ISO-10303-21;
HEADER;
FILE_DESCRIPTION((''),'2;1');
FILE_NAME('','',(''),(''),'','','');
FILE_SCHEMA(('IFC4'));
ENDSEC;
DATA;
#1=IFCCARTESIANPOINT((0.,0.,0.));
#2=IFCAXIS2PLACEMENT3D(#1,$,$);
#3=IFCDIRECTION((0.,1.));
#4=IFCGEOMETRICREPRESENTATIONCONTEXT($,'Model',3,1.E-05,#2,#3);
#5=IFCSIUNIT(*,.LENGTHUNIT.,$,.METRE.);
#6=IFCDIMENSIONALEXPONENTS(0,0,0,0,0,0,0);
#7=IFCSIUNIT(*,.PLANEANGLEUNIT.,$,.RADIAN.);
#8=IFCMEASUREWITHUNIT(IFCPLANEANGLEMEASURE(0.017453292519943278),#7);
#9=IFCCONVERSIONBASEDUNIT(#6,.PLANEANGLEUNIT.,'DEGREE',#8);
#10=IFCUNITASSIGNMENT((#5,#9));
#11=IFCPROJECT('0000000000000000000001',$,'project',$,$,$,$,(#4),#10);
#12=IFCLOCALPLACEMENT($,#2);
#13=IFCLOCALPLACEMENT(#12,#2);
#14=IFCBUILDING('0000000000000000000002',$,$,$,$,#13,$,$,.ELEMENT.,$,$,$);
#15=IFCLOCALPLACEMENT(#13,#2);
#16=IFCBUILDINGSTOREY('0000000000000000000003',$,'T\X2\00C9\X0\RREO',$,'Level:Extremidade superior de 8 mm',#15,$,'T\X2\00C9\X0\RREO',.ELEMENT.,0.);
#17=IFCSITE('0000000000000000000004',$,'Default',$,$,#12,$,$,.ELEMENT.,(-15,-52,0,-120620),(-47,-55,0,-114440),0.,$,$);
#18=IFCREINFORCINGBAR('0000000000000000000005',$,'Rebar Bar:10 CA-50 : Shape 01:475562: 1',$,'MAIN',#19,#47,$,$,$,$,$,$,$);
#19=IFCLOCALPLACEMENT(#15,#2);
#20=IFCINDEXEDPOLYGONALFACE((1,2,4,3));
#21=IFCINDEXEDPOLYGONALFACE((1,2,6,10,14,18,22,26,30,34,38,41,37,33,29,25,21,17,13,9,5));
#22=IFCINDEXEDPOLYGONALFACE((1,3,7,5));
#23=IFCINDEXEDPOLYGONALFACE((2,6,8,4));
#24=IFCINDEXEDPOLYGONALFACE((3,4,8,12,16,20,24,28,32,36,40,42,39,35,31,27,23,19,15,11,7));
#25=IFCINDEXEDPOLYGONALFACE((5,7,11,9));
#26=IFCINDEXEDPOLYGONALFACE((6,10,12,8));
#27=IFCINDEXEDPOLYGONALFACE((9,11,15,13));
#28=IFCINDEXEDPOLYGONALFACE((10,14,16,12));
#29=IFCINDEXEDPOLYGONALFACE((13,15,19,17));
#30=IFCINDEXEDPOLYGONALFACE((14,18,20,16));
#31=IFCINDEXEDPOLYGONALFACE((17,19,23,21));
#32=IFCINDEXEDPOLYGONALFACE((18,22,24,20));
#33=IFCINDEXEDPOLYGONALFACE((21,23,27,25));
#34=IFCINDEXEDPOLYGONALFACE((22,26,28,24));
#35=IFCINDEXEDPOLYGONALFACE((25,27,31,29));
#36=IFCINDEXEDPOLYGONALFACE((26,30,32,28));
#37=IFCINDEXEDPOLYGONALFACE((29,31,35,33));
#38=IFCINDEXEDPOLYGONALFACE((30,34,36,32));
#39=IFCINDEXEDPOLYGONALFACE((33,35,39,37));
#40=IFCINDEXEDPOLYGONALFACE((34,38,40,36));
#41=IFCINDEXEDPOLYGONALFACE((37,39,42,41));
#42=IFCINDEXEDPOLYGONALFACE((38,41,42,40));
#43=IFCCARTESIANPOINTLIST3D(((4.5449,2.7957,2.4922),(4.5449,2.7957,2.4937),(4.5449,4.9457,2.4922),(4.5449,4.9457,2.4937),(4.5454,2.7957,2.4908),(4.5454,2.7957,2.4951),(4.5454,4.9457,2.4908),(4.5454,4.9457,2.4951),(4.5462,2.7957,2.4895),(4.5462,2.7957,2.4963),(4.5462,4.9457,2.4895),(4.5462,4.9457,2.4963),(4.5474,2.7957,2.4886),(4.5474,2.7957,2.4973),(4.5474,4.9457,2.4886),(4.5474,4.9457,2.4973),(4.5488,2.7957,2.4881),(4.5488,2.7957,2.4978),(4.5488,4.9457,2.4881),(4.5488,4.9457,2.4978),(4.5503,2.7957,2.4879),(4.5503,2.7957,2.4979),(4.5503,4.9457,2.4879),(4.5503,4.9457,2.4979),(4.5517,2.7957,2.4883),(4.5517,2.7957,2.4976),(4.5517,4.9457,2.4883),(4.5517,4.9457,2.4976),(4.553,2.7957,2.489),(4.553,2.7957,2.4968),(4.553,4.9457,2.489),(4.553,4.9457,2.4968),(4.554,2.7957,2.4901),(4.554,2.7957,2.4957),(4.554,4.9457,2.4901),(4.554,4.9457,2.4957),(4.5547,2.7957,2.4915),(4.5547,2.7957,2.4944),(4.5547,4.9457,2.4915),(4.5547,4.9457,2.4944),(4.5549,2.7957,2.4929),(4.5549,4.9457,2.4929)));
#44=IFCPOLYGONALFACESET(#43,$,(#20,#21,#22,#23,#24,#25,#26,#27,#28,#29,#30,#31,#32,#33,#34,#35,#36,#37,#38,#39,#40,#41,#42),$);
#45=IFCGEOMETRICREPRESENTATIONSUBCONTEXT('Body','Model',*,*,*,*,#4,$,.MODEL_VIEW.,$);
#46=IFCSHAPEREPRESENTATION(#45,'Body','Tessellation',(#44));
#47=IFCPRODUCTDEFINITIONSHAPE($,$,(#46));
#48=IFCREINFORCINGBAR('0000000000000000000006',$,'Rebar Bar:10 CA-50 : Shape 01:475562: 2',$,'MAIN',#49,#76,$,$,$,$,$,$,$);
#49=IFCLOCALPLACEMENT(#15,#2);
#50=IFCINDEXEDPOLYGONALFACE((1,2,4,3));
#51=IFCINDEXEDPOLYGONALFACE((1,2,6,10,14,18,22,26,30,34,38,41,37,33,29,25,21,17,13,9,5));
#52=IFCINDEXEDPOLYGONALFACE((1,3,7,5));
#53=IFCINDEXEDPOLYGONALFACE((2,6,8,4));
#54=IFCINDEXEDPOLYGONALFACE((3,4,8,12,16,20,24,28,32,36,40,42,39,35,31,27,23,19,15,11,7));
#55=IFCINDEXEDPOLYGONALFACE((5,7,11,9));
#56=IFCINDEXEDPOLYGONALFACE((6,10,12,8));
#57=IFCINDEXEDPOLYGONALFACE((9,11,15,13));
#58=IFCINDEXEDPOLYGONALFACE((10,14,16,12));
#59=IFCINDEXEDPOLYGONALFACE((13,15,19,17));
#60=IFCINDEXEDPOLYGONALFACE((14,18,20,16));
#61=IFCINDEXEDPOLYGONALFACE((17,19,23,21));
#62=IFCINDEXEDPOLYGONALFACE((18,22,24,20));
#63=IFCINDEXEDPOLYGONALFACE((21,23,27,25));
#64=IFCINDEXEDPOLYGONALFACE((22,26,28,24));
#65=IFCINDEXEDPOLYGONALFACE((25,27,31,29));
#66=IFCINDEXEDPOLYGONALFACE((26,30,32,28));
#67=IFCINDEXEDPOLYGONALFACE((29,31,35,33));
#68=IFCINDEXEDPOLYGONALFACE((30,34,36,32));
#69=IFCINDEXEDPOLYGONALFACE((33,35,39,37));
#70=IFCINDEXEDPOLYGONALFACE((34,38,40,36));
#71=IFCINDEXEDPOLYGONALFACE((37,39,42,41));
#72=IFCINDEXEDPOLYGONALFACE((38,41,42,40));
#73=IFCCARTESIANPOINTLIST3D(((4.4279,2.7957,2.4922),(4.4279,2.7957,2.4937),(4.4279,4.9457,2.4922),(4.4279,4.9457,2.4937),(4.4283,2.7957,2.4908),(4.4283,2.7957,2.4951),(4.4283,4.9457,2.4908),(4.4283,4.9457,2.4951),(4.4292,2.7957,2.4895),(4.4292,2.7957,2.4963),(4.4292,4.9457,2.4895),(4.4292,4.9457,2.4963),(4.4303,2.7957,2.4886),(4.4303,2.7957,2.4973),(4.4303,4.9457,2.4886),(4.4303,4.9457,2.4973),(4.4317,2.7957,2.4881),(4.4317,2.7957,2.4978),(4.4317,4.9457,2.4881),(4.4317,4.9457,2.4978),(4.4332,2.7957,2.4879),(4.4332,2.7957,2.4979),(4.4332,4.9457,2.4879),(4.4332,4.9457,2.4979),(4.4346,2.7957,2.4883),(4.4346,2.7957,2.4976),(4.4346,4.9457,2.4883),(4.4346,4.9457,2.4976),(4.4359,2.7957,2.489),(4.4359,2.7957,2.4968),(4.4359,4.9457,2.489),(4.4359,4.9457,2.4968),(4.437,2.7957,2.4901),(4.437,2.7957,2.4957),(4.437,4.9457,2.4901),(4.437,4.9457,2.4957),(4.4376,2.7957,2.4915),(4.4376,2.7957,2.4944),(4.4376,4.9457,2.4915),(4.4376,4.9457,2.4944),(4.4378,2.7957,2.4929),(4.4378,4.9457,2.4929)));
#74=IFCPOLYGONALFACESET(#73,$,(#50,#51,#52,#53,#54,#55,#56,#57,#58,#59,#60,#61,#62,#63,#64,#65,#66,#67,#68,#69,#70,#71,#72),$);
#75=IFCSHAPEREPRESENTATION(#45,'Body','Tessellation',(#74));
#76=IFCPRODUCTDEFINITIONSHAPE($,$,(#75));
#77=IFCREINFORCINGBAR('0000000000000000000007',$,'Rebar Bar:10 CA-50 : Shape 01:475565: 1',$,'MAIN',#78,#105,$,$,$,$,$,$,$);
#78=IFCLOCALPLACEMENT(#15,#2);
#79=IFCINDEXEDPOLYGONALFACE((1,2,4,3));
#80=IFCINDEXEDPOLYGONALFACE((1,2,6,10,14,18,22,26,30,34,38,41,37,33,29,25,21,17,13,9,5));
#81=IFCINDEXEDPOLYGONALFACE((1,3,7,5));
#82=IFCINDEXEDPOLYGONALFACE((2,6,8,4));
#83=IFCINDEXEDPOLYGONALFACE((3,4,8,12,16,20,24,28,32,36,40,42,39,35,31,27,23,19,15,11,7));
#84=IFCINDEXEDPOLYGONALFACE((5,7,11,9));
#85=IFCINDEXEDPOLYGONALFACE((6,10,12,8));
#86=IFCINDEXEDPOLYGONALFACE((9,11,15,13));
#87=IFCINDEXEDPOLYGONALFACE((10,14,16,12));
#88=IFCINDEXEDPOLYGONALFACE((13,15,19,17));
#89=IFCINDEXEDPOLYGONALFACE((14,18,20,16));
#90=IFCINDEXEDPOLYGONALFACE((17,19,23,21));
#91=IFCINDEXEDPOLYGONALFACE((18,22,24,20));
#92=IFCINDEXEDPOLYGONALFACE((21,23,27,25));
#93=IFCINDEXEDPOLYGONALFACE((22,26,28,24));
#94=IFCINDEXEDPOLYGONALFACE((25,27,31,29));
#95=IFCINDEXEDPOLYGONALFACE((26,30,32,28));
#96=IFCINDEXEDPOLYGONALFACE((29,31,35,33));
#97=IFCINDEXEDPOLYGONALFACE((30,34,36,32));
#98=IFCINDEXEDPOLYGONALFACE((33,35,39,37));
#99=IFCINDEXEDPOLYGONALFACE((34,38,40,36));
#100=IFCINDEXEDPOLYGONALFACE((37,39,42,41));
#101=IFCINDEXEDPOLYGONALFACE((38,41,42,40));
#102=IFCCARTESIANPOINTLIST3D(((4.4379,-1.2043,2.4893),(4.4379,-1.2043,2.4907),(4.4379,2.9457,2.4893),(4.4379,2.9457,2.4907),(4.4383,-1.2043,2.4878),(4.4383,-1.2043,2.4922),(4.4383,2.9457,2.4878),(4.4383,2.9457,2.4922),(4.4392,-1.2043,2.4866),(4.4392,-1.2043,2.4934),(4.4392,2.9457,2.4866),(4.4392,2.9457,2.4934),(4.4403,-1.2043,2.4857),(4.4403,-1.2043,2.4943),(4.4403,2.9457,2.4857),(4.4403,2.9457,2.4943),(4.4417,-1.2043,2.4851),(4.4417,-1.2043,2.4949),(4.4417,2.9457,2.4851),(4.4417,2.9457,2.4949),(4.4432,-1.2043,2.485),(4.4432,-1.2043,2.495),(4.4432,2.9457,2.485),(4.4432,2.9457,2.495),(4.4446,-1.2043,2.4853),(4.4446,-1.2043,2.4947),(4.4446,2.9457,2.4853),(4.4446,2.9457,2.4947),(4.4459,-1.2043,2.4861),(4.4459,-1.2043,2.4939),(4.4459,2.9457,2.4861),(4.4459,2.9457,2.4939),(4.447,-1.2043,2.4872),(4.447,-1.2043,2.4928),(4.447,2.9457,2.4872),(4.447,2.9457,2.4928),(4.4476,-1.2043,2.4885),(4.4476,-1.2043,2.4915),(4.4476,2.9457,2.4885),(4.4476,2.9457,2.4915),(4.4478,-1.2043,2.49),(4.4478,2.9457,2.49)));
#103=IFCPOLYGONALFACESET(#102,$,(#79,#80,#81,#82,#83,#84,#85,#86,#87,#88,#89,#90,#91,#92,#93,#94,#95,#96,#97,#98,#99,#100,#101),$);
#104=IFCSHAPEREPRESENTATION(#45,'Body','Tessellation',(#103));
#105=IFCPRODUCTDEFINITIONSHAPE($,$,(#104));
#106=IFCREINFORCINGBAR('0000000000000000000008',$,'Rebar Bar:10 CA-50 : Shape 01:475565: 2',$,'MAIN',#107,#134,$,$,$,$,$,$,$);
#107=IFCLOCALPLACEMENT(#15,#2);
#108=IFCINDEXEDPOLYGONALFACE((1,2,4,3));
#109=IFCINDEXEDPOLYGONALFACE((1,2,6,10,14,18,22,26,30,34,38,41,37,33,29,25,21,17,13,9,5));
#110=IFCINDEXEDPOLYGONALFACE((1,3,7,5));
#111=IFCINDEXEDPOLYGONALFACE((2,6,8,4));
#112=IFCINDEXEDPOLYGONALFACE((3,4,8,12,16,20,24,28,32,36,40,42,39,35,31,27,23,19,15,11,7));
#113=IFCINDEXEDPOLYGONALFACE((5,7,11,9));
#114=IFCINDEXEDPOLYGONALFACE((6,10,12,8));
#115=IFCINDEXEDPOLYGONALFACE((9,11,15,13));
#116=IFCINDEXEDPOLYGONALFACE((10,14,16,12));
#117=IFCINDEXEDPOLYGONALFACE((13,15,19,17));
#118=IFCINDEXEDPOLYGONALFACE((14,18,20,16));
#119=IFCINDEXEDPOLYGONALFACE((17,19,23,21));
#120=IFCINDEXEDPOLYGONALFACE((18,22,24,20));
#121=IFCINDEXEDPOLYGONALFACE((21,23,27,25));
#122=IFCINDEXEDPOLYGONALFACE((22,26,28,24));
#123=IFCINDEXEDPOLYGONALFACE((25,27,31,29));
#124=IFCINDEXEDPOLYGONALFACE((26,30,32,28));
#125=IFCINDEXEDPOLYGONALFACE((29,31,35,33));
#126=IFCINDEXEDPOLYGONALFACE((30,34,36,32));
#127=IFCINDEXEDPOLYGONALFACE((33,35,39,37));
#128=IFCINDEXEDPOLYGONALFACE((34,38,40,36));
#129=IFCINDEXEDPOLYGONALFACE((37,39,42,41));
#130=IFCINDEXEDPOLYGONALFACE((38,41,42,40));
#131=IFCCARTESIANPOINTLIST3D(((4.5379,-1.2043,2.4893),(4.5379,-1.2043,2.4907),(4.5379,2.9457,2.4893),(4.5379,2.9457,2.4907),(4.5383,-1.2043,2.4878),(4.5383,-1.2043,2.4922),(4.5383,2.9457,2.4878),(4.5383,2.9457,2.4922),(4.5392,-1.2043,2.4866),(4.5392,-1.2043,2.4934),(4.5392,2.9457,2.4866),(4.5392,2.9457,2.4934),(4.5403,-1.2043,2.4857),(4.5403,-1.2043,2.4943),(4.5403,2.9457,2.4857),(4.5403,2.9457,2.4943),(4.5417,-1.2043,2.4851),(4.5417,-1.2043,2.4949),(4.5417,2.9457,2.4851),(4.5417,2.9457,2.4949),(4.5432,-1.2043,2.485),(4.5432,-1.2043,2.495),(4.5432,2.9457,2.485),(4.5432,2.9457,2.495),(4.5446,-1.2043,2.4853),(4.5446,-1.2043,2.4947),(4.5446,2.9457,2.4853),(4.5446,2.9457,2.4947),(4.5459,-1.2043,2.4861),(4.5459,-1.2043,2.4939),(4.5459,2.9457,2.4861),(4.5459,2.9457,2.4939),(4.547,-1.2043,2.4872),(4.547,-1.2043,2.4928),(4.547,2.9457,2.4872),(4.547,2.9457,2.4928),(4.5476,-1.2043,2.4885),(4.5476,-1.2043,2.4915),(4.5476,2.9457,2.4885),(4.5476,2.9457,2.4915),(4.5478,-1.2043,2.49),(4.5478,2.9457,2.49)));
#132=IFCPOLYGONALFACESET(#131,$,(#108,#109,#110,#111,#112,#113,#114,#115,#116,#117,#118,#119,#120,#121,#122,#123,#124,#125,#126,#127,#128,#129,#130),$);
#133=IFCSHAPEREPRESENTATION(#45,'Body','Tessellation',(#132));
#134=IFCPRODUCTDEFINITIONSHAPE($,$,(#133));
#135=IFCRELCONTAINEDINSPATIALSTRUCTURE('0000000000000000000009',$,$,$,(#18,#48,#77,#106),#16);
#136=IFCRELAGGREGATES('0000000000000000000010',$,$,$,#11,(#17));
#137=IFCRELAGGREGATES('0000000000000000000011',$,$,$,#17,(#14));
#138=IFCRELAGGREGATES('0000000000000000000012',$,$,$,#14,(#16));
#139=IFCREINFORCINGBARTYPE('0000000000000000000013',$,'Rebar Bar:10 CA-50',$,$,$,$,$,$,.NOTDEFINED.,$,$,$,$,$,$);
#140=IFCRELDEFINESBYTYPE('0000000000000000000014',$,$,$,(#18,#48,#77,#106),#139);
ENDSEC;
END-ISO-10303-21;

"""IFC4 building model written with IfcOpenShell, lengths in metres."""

from ifc_helpers import new_model, entity, si_unit, converted_unit, direction, origin, place, context, subcontext, project, spatial, type_object, element, save


model = new_model("IFC4")

# Units and contexts
model_context = context("Model", 3, precision=1e-05, world=origin(), true_north=direction((0.0, 1.0)))
body_context = subcontext(model_context, "Body", "Model", "MODEL_VIEW")
ifc_project = project(units=[si_unit("LENGTHUNIT", "METRE"), converted_unit("PLANEANGLEUNIT", "DEGREE", entity("IfcPlaneAngleMeasure", 0.017453292519943278), si_unit("PLANEANGLEUNIT", "RADIAN"), dimensions=[0, 0, 0, 0, 0, 0, 0])], contexts=[model_context])

# Site, building, storey
site_placement = place(None, origin())
site = spatial("IfcSite", under=ifc_project, at=site_placement, Name="Default", CompositionType="ELEMENT", RefLatitude=(-15, -52, 0, -120620), RefLongitude=(-47, -55, 0, -114440), RefElevation=0.0)
building_placement = place(site_placement, origin())
building = spatial("IfcBuilding", under=site, at=building_placement, CompositionType="ELEMENT")
storey_placement = place(building_placement, origin())
storey = spatial("IfcBuildingStorey", under=building, at=storey_placement, Name="TÉRREO", ObjectType="Level:Extremidade superior de 8 mm", LongName="TÉRREO", CompositionType="ELEMENT", Elevation=0.0)

# Reinforcing bars
reinforcing_bar_type_1 = type_object("IfcReinforcingBarType", Name="Rebar Bar:10 CA-50", PredefinedType="NOTDEFINED")
reinforcing_bar_1_placement = place(storey_placement, origin())
element("IfcReinforcingBar", 1, at=reinforcing_bar_1_placement, inside=storey, type_object=reinforcing_bar_type_1, Name="Rebar Bar:10 CA-50 : Shape 01:475562: 1", ObjectType="MAIN", context=body_context, shape_type="AdvancedSweptSolid", body=[
    entity("IfcSweptDiskSolid", entity("IfcIndexedPolyCurve", entity("IfcCartesianPointList3D", [[4.5499, 2.7957, 2.4929], [4.5499, 4.9457, 2.4929]]), None, False), 0.005, None, 0.0, 1.0),
])
reinforcing_bar_2_placement = place(storey_placement, origin())
element("IfcReinforcingBar", 2, at=reinforcing_bar_2_placement, inside=storey, type_object=reinforcing_bar_type_1, Name="Rebar Bar:10 CA-50 : Shape 01:475562: 2", ObjectType="MAIN", context=body_context, shape_type="AdvancedSweptSolid", body=[
    entity("IfcSweptDiskSolid", entity("IfcIndexedPolyCurve", entity("IfcCartesianPointList3D", [[4.4328, 2.7957, 2.4929], [4.4328, 4.9457, 2.4929]]), None, False), 0.005, None, 0.0, 1.0),
])
reinforcing_bar_3_placement = place(storey_placement, origin())
element("IfcReinforcingBar", 3, at=reinforcing_bar_3_placement, inside=storey, type_object=reinforcing_bar_type_1, Name="Rebar Bar:10 CA-50 : Shape 01:475565: 1", ObjectType="MAIN", context=body_context, shape_type="AdvancedSweptSolid", body=[
    entity("IfcSweptDiskSolid", entity("IfcIndexedPolyCurve", entity("IfcCartesianPointList3D", [[4.4428, -1.2043, 2.49], [4.4428, 2.9457, 2.49]]), None, False), 0.005, None, 0.0, 1.0),
])
reinforcing_bar_4_placement = place(storey_placement, origin())
element("IfcReinforcingBar", 4, at=reinforcing_bar_4_placement, inside=storey, type_object=reinforcing_bar_type_1, Name="Rebar Bar:10 CA-50 : Shape 01:475565: 2", ObjectType="MAIN", context=body_context, shape_type="AdvancedSweptSolid", body=[
    entity("IfcSweptDiskSolid", entity("IfcIndexedPolyCurve", entity("IfcCartesianPointList3D", [[4.5428, -1.2043, 2.49], [4.5428, 2.9457, 2.49]]), None, False), 0.005, None, 0.0, 1.0),
])

save(model, "model.ifc")
